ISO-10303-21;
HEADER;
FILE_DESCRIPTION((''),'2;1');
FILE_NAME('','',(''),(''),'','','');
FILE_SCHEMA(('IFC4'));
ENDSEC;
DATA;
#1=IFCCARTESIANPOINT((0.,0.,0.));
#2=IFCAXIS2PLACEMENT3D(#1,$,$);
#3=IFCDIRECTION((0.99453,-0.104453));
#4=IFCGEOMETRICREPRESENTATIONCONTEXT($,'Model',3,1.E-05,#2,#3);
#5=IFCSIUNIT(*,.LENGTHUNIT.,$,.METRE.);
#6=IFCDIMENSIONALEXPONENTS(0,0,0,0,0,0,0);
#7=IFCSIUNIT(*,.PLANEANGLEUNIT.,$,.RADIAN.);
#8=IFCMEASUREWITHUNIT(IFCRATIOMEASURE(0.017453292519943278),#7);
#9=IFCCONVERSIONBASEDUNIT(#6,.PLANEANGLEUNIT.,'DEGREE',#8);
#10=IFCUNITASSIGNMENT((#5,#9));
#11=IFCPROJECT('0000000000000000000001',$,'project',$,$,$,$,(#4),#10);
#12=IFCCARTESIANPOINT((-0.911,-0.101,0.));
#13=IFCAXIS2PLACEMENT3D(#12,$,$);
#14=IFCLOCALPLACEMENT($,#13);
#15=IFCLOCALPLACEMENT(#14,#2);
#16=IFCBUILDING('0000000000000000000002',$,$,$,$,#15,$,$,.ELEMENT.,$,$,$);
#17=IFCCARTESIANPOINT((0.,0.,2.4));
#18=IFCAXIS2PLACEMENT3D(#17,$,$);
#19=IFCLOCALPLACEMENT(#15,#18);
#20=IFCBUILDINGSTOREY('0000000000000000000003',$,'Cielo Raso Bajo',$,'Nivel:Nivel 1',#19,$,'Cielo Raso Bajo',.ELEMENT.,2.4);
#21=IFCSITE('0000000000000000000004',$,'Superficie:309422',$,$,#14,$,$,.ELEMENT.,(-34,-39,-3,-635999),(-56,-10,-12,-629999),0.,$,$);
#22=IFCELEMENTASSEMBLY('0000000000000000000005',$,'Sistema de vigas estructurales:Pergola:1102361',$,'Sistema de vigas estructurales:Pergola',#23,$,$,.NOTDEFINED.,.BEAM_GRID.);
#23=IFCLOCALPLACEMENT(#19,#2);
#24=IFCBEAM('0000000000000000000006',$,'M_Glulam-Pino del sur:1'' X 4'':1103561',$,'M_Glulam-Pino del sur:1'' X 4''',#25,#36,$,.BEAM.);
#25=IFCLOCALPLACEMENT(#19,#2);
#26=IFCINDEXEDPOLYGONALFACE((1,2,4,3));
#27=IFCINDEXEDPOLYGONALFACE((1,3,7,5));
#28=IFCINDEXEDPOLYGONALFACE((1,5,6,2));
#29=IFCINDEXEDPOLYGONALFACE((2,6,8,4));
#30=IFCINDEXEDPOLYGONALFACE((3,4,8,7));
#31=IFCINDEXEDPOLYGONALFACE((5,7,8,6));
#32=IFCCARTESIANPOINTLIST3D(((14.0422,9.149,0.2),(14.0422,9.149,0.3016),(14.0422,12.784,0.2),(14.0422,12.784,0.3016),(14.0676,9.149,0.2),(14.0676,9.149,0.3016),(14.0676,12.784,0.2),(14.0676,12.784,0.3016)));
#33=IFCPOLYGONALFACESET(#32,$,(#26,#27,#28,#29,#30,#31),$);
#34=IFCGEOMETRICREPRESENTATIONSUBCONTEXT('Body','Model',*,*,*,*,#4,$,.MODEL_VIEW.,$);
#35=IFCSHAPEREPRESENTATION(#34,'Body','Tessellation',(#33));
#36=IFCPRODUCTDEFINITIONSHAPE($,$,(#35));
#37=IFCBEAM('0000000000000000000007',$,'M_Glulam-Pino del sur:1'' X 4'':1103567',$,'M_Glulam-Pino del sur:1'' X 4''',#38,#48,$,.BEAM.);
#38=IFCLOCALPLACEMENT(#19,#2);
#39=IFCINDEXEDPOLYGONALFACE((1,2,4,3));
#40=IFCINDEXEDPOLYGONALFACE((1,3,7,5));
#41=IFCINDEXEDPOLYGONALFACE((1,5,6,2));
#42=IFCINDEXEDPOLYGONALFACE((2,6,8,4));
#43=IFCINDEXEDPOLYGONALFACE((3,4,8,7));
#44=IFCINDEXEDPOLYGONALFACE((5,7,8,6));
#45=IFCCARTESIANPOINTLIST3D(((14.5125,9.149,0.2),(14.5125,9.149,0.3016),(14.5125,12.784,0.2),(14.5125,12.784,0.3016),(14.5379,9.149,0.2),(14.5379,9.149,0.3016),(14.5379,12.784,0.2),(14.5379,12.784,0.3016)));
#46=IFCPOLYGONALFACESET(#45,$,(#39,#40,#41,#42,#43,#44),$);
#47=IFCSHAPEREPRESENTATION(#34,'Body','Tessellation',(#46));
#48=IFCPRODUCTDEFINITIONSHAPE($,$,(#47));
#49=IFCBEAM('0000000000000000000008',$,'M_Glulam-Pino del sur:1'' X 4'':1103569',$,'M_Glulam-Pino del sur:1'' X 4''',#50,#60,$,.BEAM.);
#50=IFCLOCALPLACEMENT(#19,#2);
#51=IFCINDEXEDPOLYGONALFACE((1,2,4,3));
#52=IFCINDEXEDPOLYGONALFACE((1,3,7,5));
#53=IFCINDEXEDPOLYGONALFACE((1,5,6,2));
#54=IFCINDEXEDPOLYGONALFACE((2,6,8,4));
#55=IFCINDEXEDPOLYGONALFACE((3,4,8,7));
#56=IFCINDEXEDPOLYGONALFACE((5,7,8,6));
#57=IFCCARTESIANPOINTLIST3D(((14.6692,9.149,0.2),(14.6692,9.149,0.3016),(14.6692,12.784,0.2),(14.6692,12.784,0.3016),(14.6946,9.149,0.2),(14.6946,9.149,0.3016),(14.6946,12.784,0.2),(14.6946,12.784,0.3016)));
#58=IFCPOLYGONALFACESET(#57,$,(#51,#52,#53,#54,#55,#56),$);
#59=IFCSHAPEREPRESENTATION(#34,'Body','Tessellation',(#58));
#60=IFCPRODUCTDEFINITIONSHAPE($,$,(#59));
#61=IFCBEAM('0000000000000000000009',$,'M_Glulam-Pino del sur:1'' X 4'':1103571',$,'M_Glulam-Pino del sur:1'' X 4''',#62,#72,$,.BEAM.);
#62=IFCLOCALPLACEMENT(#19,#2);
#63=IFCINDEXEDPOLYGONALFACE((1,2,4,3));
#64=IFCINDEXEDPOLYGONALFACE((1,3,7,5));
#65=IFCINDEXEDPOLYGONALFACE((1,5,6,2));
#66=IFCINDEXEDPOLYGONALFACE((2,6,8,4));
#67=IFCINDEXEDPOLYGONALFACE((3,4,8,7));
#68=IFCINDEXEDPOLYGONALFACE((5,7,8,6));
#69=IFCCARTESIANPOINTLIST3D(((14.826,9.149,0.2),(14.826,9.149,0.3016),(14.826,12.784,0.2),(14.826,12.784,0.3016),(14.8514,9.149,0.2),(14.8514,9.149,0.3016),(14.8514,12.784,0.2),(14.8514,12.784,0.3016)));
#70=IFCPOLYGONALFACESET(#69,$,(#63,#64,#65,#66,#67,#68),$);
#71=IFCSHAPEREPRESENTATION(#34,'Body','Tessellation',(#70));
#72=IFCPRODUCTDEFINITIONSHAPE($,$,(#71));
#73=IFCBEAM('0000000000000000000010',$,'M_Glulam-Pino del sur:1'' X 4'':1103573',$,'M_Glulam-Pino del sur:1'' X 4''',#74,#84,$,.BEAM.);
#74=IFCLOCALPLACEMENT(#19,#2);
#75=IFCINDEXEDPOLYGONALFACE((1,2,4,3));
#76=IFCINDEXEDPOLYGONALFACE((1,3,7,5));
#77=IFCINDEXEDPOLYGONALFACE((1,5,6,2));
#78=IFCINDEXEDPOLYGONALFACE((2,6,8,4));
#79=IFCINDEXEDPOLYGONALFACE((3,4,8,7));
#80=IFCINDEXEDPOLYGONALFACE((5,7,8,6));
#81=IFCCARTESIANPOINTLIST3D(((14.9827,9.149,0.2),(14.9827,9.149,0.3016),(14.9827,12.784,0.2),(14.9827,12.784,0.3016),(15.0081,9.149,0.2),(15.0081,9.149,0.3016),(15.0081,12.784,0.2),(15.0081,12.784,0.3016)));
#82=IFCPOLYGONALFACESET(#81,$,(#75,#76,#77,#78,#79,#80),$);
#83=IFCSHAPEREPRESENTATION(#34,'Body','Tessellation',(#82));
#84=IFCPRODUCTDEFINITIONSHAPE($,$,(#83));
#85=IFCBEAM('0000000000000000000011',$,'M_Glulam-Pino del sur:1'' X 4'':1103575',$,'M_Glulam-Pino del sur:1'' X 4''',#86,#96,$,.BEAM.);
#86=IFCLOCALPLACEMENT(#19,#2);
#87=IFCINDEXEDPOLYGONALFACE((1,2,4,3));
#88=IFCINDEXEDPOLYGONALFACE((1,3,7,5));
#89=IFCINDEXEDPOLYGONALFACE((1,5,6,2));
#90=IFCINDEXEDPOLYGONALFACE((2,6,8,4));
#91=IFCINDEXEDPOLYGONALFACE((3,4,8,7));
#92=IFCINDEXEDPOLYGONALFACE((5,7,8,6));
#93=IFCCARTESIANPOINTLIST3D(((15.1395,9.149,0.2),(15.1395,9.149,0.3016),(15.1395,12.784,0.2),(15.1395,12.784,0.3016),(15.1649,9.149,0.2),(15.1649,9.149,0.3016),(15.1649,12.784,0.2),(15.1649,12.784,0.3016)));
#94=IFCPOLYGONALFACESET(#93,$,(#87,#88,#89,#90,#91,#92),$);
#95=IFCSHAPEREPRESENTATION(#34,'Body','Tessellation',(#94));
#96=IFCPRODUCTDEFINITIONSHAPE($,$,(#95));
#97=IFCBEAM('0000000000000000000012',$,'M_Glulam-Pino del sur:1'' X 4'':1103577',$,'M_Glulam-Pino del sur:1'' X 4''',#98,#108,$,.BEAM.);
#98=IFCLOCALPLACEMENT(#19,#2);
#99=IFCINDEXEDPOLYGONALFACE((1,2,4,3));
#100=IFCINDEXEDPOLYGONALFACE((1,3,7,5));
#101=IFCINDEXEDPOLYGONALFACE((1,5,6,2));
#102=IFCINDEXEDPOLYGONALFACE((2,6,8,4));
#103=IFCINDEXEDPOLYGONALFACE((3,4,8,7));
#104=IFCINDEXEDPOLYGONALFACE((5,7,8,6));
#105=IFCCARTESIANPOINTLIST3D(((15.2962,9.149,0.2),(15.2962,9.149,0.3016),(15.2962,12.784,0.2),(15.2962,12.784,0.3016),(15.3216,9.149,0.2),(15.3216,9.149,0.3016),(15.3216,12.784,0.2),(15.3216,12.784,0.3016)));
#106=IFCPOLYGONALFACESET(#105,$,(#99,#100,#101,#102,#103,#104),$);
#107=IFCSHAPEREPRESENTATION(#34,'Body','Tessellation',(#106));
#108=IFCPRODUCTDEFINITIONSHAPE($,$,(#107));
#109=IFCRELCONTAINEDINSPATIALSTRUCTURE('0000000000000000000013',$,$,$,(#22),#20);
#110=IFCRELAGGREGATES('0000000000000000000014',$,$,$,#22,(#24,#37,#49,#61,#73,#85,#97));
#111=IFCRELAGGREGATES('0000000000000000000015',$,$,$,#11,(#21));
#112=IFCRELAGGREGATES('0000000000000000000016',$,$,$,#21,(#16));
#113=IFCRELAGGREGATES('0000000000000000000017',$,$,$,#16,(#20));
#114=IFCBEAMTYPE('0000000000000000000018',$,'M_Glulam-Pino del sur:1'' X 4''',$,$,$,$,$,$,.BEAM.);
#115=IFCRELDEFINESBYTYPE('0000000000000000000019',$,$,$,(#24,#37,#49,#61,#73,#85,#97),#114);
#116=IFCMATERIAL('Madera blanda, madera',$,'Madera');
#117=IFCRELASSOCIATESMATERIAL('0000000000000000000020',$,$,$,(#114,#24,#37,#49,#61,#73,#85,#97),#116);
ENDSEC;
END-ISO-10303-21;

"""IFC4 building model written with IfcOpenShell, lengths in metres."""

from ifc_helpers import new_model, entity, si_unit, converted_unit, direction, frame, origin, origin_2d_with_axis, place, context, subcontext, project, spatial, polyline, segment, composite_curve, rectangle, outline, extrude, source, transform, mapped, material, material_profile, profile_set, profile_usage, type_object, type_shapes, element, aggregate, save


model = new_model("IFC4")

# Units and contexts
model_context = context("Model", 3, precision=1e-05, world=origin(), true_north=direction((0.99453, -0.104453)))
body_context = subcontext(model_context, "Body", "Model", "MODEL_VIEW")
ifc_project = project(units=[si_unit("LENGTHUNIT", "METRE"), converted_unit("PLANEANGLEUNIT", "DEGREE", entity("IfcRatioMeasure", 0.017453292519943278), si_unit("PLANEANGLEUNIT", "RADIAN"), dimensions=[0, 0, 0, 0, 0, 0, 0])], contexts=[model_context])

# Site, building, storey
site_placement = place(None, frame((-0.911, -0.101, 0.0)))
site = spatial("IfcSite", under=ifc_project, at=site_placement, Name="Superficie:309422", CompositionType="ELEMENT", RefLatitude=(-34, -39, -3, -635999), RefLongitude=(-56, -10, -12, -629999), RefElevation=0.0)
building_placement = place(site_placement, origin())
building = spatial("IfcBuilding", under=site, at=building_placement, CompositionType="ELEMENT")
storey_placement = place(building_placement, frame((0.0, 0.0, 2.4)))
storey = spatial("IfcBuildingStorey", under=building, at=storey_placement, Name="Cielo Raso Bajo", ObjectType="Nivel:Nivel 1", LongName="Cielo Raso Bajo", CompositionType="ELEMENT", Elevation=2.4)

# Element assembly, beams
assembly_placement = place(storey_placement, origin())
assembly = element("IfcElementAssembly", 1, at=assembly_placement, inside=storey, Name="Sistema de vigas estructurales:Pergola:1102361", ObjectType="Sistema de vigas estructurales:Pergola", AssemblyPlace="NOTDEFINED", PredefinedType="BEAM_GRID")
ifc_material = material(Name="Madera blanda, madera", Category="Madera")
ifc_material_profile_1 = material_profile(ifc_material, outline(composite_curve([segment(polyline([(-0.0127, 0.0508, 0.0), (0.0127, 0.0508, 0.0)]), True, "CONTINUOUS"), segment(polyline([(0.0127, 0.0508, 0.0), (0.0127, -0.0508, 0.0)]), True, "CONTINUOUS"), segment(polyline([(0.0127, -0.0508, 0.0), (-0.0127, -0.0508, 0.0)]), True, "CONTINUOUS"), segment(polyline([(-0.0127, -0.0508, 0.0), (-0.0127, 0.0508, 0.0)]), True, "CONTINUOUS")], self_intersect=False), kind="CURVE"), Name="1' X 4'")
ifc_material_profile_2 = material_profile(ifc_material, outline(composite_curve([segment(polyline([(2.5145, -0.0127, -0.0508), (2.5145, -0.0127, 0.0508)]), True, "CONTINUOUS"), segment(polyline([(2.5145, -0.0127, 0.0508), (-2.5145, -0.0127, 0.0508)]), True, "CONTINUOUS"), segment(polyline([(-2.5145, -0.0127, 0.0508), (-2.5145, -0.0127, -0.0508)]), True, "CONTINUOUS"), segment(polyline([(-2.5145, -0.0127, -0.0508), (2.5145, -0.0127, -0.0508)]), True, "CONTINUOUS")], self_intersect=False), kind="CURVE"), Name="1' X 4'")
ifc_profile_set = profile_set([ifc_material_profile_1, ifc_material_profile_2], Name="1' X 4'")
beam_type = type_object("IfcBeamType", Name="M_Glulam-Pino del sur:1' X 4'", PredefinedType="BEAM", material=ifc_profile_set)
shared_shape = source(origin(), body_context, "Body", "SweptSolid", [
    extrude(rectangle(XDim=0.1016, YDim=0.0254, at=origin_2d_with_axis()), frame((-1.7485, 0.0, 0.0), z_axis=(1.0, 0.0, 0.0), x_axis=(0.0, 0.0, -1.0)), (0.0, 0.0, 1.0), 3.635),
])
type_shapes(beam_type, [shared_shape])
ifc_profile_usage_1 = profile_usage(ifc_profile_set, cardinal=8)
beam_1_placement = place(assembly_placement, frame((14.0549, 10.8975, 0.2508), z_axis=(0.0, 0.0, 1.0), x_axis=(0.0, 1.0, 0.0)))
beam_1 = element("IfcBeam", 2, at=beam_1_placement, type_object=beam_type, material=ifc_profile_usage_1, Name="M_Glulam-Pino del sur:1' X 4':1103561", ObjectType="M_Glulam-Pino del sur:1' X 4'", PredefinedType="BEAM", context=body_context, shape_type="MappedRepresentation", body=[
    mapped(shared_shape, transform((0.0, 0.0, 0.0), scale=1.0)),
])
ifc_profile_usage_2 = profile_usage(ifc_profile_set, cardinal=8)
beam_2_placement = place(assembly_placement, frame((14.5252, 10.8975, 0.2508), z_axis=(0.0, 0.0, 1.0), x_axis=(0.0, 1.0, 0.0)))
beam_2 = element("IfcBeam", 3, at=beam_2_placement, type_object=beam_type, material=ifc_profile_usage_2, Name="M_Glulam-Pino del sur:1' X 4':1103567", ObjectType="M_Glulam-Pino del sur:1' X 4'", PredefinedType="BEAM", context=body_context, shape_type="MappedRepresentation", body=[
    mapped(shared_shape, transform((0.0, 0.0, 0.0), scale=1.0)),
])
ifc_profile_usage_3 = profile_usage(ifc_profile_set, cardinal=8)
beam_3_placement = place(assembly_placement, frame((14.6819, 10.8975, 0.2508), z_axis=(0.0, 0.0, 1.0), x_axis=(0.0, 1.0, 0.0)))
beam_3 = element("IfcBeam", 4, at=beam_3_placement, type_object=beam_type, material=ifc_profile_usage_3, Name="M_Glulam-Pino del sur:1' X 4':1103569", ObjectType="M_Glulam-Pino del sur:1' X 4'", PredefinedType="BEAM", context=body_context, shape_type="MappedRepresentation", body=[
    mapped(shared_shape, transform((0.0, 0.0, 0.0), scale=1.0)),
])
ifc_profile_usage_4 = profile_usage(ifc_profile_set, cardinal=8)
beam_4_placement = place(assembly_placement, frame((14.8387, 10.8975, 0.2508), z_axis=(0.0, 0.0, 1.0), x_axis=(0.0, 1.0, 0.0)))
beam_4 = element("IfcBeam", 5, at=beam_4_placement, type_object=beam_type, material=ifc_profile_usage_4, Name="M_Glulam-Pino del sur:1' X 4':1103571", ObjectType="M_Glulam-Pino del sur:1' X 4'", PredefinedType="BEAM", context=body_context, shape_type="MappedRepresentation", body=[
    mapped(shared_shape, transform((0.0, 0.0, 0.0), scale=1.0)),
])
ifc_profile_usage_5 = profile_usage(ifc_profile_set, cardinal=8)
beam_5_placement = place(assembly_placement, frame((14.9954, 10.8975, 0.2508), z_axis=(0.0, 0.0, 1.0), x_axis=(0.0, 1.0, 0.0)))
beam_5 = element("IfcBeam", 6, at=beam_5_placement, type_object=beam_type, material=ifc_profile_usage_5, Name="M_Glulam-Pino del sur:1' X 4':1103573", ObjectType="M_Glulam-Pino del sur:1' X 4'", PredefinedType="BEAM", context=body_context, shape_type="MappedRepresentation", body=[
    mapped(shared_shape, transform((0.0, 0.0, 0.0), scale=1.0)),
])
ifc_profile_usage_6 = profile_usage(ifc_profile_set, cardinal=8)
beam_6_placement = place(assembly_placement, frame((15.1522, 10.8975, 0.2508), z_axis=(0.0, 0.0, 1.0), x_axis=(0.0, 1.0, 0.0)))
beam_6 = element("IfcBeam", 7, at=beam_6_placement, type_object=beam_type, material=ifc_profile_usage_6, Name="M_Glulam-Pino del sur:1' X 4':1103575", ObjectType="M_Glulam-Pino del sur:1' X 4'", PredefinedType="BEAM", context=body_context, shape_type="MappedRepresentation", body=[
    mapped(shared_shape, transform((0.0, 0.0, 0.0), scale=1.0)),
])
ifc_profile_usage_7 = profile_usage(ifc_profile_set, cardinal=8)
beam_7_placement = place(assembly_placement, frame((15.3089, 10.8975, 0.2508), z_axis=(0.0, 0.0, 1.0), x_axis=(0.0, 1.0, 0.0)))
beam_7 = element("IfcBeam", 8, at=beam_7_placement, type_object=beam_type, material=ifc_profile_usage_7, Name="M_Glulam-Pino del sur:1' X 4':1103577", ObjectType="M_Glulam-Pino del sur:1' X 4'", PredefinedType="BEAM", context=body_context, shape_type="MappedRepresentation", body=[
    mapped(shared_shape, transform((0.0, 0.0, 0.0), scale=1.0)),
])
aggregate(assembly, [beam_1, beam_2, beam_3, beam_4, beam_5, beam_6, beam_7])

save(model, "model.ifc")
